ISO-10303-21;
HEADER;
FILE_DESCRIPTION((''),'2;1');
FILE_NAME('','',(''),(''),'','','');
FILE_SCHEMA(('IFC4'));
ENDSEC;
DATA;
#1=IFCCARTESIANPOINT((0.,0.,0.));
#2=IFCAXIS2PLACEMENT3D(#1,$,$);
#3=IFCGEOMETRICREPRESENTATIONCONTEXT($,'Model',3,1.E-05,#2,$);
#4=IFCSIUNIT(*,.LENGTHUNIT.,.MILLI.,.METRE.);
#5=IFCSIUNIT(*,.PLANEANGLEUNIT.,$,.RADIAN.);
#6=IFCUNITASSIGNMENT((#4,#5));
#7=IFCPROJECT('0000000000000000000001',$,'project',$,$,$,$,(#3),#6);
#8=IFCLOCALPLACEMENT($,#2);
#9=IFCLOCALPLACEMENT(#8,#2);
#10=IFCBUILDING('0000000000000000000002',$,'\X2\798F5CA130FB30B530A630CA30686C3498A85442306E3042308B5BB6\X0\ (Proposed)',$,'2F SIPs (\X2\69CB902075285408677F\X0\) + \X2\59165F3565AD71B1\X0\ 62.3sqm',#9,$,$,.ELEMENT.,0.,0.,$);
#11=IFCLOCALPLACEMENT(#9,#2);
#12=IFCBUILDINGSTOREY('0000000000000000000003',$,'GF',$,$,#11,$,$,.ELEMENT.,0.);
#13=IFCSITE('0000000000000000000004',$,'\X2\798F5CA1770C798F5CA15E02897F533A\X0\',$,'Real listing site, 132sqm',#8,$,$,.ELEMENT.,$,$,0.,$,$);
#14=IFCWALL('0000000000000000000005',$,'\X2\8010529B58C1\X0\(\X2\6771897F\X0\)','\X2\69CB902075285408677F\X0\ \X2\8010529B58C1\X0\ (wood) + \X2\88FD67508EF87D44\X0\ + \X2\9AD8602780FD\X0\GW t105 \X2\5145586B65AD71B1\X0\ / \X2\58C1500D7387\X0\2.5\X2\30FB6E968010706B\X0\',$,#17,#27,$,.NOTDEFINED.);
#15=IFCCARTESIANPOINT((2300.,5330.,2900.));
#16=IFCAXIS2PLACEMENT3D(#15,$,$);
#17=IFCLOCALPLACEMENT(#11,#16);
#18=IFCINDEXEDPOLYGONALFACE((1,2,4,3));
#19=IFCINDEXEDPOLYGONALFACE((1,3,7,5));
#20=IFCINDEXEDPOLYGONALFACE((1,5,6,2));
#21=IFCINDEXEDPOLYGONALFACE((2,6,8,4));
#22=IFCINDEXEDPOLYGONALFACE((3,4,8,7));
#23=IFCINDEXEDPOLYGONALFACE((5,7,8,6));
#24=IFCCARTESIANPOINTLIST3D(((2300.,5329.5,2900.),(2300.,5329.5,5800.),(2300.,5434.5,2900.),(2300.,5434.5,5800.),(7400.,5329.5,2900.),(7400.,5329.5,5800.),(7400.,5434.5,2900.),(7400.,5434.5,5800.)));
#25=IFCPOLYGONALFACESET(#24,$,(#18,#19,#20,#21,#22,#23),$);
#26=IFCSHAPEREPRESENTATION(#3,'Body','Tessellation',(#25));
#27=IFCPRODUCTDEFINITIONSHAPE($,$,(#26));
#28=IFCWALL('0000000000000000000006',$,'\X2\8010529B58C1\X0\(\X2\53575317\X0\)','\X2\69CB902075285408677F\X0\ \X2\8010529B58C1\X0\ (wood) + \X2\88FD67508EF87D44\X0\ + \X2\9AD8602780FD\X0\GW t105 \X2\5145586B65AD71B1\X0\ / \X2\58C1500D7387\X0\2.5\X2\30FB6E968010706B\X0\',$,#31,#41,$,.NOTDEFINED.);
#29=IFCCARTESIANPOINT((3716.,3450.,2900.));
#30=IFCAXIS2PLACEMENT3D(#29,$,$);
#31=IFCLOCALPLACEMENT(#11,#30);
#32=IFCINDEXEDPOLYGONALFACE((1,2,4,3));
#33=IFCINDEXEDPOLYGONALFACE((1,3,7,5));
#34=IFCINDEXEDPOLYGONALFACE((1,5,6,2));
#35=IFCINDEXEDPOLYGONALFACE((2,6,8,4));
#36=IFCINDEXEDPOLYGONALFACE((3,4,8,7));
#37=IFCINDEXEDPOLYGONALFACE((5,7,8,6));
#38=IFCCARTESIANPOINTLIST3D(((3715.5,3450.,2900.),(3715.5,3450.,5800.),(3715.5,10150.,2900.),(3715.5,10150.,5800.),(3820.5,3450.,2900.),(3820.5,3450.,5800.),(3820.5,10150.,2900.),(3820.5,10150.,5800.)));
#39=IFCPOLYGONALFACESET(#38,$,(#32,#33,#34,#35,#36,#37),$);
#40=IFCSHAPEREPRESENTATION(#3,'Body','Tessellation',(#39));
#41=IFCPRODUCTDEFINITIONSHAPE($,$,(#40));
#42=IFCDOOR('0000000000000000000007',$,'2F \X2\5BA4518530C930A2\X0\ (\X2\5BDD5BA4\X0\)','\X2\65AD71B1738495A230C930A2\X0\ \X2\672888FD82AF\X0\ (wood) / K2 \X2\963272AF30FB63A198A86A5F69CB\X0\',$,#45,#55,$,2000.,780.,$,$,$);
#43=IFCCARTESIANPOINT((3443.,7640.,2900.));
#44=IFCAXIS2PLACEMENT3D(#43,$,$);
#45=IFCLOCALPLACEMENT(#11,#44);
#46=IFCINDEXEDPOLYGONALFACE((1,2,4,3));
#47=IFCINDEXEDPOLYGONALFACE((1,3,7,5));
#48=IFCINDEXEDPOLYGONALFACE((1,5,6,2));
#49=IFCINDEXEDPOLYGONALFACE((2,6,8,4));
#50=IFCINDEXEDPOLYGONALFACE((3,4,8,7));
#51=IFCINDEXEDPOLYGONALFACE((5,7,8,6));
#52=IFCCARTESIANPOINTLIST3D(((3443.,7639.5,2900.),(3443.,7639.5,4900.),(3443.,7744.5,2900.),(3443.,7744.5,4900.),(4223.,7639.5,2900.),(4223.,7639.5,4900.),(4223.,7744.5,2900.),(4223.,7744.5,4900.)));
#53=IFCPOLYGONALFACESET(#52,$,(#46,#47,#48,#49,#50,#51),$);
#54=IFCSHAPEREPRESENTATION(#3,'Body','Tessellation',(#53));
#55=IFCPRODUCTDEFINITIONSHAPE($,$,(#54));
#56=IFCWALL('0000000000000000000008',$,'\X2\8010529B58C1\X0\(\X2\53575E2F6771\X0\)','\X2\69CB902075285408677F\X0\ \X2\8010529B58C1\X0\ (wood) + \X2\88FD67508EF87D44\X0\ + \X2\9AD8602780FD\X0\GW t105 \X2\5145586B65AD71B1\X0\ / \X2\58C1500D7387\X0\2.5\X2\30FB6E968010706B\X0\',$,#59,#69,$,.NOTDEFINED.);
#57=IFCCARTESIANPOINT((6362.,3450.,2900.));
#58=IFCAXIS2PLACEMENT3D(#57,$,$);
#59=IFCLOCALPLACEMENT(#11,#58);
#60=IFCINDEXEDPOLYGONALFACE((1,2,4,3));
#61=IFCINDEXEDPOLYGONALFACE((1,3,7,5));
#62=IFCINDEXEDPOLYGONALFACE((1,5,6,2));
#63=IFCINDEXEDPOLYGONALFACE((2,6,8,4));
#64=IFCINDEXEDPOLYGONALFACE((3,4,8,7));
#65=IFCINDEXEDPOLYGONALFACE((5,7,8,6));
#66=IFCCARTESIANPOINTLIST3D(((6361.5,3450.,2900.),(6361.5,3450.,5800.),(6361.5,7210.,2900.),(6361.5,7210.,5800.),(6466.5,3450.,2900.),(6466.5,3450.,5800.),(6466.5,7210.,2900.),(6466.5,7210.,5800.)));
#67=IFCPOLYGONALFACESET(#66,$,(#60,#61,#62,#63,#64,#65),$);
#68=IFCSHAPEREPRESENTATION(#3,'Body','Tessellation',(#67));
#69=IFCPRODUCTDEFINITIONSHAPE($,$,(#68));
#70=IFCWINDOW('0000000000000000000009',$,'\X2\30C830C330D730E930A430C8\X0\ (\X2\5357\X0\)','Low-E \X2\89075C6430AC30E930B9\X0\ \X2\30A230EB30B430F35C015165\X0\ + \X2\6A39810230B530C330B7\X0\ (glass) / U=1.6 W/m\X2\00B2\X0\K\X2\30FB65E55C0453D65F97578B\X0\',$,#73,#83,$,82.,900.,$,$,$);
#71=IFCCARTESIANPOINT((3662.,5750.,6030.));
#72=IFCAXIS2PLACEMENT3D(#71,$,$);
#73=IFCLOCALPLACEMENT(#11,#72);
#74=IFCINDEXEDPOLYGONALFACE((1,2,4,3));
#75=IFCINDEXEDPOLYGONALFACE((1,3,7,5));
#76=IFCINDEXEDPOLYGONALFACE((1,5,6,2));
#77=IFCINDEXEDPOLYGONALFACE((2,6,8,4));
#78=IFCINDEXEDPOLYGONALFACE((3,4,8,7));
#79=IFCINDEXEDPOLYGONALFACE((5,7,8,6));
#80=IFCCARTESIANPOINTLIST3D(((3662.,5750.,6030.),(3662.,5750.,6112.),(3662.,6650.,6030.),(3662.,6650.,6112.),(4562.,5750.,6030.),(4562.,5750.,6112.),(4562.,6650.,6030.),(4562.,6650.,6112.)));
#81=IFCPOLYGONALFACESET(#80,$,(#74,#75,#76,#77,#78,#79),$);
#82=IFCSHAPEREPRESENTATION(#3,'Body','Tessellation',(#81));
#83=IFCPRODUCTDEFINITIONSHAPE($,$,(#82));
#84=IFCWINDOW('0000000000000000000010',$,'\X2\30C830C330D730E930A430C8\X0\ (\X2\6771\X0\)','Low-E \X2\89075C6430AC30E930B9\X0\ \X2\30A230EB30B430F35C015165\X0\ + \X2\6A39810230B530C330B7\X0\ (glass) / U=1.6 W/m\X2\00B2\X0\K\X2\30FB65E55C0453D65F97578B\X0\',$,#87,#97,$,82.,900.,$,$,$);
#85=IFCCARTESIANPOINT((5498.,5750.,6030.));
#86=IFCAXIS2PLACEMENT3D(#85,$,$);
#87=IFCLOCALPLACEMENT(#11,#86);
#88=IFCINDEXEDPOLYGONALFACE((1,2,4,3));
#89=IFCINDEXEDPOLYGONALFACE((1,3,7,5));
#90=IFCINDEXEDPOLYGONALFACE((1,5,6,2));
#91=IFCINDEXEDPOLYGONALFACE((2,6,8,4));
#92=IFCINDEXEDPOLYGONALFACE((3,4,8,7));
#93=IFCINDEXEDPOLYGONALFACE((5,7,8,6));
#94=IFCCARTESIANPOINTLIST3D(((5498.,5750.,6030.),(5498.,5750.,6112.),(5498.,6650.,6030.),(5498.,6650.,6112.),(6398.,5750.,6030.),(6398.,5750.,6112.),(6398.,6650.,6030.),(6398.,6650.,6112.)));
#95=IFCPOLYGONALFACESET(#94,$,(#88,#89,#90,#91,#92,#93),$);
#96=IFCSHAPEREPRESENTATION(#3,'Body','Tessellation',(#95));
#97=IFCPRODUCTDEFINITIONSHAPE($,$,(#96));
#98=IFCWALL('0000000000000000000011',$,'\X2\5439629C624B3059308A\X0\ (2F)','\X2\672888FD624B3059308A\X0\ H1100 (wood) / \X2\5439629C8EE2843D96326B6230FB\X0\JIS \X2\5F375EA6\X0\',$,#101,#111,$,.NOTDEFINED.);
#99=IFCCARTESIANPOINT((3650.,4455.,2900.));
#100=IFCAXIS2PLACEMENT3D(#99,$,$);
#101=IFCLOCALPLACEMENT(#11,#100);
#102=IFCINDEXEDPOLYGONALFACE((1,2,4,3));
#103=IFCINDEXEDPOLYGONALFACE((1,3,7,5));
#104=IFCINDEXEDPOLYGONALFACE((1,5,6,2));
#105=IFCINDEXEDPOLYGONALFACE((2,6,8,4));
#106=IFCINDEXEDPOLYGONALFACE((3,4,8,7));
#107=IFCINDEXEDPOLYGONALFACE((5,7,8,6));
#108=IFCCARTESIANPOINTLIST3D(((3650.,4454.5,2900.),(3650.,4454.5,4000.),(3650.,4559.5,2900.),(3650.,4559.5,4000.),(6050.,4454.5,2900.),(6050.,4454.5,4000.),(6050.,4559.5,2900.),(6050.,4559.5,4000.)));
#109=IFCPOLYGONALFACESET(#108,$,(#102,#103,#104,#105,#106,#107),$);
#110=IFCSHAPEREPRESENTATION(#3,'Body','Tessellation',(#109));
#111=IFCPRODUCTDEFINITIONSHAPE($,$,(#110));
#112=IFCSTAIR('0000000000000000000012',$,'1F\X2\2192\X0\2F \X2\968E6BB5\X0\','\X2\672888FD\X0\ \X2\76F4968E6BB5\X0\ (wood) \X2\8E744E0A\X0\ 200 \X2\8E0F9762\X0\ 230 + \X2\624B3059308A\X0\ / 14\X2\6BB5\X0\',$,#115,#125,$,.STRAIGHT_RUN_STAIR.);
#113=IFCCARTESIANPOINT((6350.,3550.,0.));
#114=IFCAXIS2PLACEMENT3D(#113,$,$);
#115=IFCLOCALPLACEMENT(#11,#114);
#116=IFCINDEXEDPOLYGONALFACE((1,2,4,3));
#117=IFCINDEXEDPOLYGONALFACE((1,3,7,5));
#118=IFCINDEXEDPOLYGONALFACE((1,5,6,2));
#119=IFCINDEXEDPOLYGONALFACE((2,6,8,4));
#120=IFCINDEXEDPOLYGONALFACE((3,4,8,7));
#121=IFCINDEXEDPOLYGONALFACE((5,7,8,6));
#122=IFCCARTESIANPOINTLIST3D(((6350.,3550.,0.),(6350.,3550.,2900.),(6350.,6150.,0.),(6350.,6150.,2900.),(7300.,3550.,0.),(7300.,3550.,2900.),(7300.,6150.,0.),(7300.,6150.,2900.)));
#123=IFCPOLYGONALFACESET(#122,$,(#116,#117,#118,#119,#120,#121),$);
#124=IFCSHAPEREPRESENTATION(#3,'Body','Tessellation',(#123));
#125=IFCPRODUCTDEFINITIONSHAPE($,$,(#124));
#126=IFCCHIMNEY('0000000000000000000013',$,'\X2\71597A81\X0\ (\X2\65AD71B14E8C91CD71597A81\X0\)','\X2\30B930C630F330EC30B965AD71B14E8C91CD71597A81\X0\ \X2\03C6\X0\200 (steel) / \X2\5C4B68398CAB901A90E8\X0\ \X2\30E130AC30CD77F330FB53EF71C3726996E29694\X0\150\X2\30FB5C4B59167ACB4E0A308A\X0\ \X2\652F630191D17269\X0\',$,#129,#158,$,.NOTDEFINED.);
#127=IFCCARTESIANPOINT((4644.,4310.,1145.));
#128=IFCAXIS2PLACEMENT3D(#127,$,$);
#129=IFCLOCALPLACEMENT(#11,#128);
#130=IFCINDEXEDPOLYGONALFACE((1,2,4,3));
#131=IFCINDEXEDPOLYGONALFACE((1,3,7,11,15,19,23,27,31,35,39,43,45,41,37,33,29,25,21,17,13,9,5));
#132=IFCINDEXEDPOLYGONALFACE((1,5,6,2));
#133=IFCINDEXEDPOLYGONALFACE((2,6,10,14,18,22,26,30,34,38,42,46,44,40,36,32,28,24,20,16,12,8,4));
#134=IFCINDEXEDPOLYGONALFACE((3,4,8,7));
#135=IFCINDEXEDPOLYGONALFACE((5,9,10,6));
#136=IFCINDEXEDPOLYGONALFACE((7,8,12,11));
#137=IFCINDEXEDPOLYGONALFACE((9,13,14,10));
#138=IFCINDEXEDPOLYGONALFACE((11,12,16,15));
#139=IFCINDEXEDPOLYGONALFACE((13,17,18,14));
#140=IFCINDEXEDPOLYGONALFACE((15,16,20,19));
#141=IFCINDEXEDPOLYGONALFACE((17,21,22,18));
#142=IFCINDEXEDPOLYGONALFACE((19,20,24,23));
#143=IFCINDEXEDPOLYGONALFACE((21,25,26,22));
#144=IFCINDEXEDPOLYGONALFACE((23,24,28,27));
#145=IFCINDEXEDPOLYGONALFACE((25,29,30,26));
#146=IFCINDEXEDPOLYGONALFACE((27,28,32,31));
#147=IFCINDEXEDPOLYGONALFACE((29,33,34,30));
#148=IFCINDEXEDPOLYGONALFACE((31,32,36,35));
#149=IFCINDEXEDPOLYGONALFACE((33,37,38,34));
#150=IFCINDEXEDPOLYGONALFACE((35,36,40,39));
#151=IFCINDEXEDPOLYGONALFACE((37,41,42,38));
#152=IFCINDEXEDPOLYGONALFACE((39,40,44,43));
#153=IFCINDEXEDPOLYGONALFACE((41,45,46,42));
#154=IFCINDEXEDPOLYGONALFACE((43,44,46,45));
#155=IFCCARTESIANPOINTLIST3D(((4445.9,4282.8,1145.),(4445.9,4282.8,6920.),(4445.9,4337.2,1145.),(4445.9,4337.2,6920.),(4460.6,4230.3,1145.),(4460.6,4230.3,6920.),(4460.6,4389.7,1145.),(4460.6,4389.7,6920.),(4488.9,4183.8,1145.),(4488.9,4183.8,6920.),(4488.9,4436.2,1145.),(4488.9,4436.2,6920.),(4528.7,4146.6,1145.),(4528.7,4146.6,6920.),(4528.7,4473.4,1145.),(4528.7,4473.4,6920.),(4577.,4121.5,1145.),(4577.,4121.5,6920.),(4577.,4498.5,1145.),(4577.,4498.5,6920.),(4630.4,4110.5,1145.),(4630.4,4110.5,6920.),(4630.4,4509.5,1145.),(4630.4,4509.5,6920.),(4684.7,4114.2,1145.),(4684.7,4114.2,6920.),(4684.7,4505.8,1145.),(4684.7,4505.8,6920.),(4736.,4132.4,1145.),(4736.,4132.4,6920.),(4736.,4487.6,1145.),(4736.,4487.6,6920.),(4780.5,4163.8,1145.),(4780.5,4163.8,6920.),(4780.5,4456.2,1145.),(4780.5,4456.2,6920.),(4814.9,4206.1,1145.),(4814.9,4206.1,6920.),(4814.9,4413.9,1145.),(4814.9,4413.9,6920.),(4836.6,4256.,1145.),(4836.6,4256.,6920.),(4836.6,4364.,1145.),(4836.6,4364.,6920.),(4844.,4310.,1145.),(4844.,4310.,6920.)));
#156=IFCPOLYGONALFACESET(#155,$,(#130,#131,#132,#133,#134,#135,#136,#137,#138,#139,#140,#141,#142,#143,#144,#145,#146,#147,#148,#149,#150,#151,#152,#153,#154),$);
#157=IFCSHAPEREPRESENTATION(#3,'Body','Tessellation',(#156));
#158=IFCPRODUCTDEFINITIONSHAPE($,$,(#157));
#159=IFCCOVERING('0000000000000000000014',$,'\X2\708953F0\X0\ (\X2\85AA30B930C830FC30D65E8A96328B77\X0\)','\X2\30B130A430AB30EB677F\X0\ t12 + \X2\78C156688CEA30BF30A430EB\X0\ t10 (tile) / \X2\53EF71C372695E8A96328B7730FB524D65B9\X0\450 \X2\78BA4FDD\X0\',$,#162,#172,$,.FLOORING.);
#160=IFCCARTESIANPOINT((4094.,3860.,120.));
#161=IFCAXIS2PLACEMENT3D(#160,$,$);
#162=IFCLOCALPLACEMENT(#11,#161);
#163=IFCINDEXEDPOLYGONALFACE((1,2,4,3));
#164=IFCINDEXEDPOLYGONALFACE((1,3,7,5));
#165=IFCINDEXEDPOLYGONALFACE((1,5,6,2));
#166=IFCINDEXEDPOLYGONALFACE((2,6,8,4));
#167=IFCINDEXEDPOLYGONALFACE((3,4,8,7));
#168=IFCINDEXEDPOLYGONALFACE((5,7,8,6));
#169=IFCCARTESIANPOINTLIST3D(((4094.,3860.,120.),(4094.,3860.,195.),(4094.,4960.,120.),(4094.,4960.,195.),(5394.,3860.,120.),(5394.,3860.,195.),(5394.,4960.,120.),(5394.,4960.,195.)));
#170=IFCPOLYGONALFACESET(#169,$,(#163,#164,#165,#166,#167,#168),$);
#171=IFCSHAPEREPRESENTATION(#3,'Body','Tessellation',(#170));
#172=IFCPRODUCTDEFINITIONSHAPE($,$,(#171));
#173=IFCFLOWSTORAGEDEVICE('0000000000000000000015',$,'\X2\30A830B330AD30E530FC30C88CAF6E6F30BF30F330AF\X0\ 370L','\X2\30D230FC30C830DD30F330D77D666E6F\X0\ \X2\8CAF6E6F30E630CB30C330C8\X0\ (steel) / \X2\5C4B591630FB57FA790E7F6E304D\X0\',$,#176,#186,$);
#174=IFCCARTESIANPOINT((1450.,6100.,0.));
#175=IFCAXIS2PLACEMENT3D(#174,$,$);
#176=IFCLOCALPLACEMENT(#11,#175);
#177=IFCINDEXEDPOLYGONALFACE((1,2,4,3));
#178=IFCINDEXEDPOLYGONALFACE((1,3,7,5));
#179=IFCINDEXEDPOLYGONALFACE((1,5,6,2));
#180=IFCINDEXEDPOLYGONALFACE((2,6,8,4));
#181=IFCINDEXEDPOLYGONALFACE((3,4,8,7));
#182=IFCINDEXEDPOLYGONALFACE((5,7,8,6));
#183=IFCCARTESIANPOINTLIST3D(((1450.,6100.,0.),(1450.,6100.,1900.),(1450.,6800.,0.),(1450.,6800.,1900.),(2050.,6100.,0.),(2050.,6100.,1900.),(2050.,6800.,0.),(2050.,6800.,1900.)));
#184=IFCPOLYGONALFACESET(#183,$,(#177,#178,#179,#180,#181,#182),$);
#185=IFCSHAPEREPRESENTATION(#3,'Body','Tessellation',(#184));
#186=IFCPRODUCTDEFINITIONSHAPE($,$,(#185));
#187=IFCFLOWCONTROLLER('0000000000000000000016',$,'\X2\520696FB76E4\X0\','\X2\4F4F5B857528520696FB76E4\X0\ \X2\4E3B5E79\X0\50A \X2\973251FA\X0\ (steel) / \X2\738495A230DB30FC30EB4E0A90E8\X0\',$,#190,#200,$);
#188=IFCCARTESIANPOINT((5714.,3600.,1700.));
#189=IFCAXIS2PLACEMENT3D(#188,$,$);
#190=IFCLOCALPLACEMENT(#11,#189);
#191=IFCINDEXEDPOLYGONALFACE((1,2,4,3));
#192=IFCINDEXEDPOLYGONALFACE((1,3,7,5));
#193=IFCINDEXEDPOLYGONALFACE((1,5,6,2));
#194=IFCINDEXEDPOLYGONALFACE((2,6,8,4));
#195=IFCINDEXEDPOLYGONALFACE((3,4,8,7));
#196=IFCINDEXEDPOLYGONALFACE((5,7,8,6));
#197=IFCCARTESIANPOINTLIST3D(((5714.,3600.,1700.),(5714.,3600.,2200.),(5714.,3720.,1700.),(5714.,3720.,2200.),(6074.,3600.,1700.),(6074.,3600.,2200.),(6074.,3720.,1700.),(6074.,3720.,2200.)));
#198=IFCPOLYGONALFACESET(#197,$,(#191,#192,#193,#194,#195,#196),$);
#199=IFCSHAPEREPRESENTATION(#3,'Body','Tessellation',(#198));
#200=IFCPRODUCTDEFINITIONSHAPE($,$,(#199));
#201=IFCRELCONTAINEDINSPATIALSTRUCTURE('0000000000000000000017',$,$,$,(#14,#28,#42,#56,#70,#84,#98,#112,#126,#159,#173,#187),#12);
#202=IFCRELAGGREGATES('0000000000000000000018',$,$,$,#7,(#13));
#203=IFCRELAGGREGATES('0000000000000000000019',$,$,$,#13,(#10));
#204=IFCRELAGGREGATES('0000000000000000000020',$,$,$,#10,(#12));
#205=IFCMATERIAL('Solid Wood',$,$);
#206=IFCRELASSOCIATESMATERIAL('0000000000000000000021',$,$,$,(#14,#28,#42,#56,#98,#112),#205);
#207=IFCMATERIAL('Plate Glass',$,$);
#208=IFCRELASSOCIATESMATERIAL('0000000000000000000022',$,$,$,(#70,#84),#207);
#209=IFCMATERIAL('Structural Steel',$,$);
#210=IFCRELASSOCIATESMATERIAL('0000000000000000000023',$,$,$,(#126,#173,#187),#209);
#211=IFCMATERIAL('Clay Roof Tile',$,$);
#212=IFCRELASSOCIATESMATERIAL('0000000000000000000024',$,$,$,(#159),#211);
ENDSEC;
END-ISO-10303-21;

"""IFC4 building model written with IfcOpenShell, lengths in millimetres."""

from ifc_helpers import new_model, si_unit, frame, frame_2d, origin, origin_2d, place, context, project, spatial, rectangle, circle, extrude, material, element, fill, save


model = new_model("IFC4")

# Units and contexts
model_context = context("Model", 3, precision=1e-05, world=origin())
ifc_project = project(units=[si_unit("LENGTHUNIT", "METRE", prefix="MILLI"), si_unit("PLANEANGLEUNIT", "RADIAN")], contexts=[model_context])

# Site, building, storey
site_placement = place(None, origin())
site = spatial("IfcSite", under=ifc_project, at=site_placement, Name="福岡県福岡市西区", ObjectType="Real listing site, 132sqm", CompositionType="ELEMENT", RefElevation=0.0)
building_placement = place(site_placement, origin())
building = spatial("IfcBuilding", under=site, at=building_placement, Name="福岡・サウナと水風呂のある家 (Proposed)", ObjectType="2F SIPs (構造用合板) + 外張断熱 62.3sqm", CompositionType="ELEMENT", ElevationOfRefHeight=0.0, ElevationOfTerrain=0.0)
storey_placement = place(building_placement, origin())
storey = spatial("IfcBuildingStorey", under=building, at=storey_placement, Name="GF", CompositionType="ELEMENT", Elevation=0.0)

# Shared definitions
ifc_material_1 = material(Name="Solid Wood")

# Wall
wall_1_placement = place(storey_placement, frame((2300.0, 5330.0, 2900.0)))
element("IfcWall", 1, at=wall_1_placement, inside=storey, material=ifc_material_1, Name="耐力壁(東西)", Description="構造用合板 耐力壁 (wood) + 製材軸組 + 高性能GW t105 充填断熱 / 壁倍率2.5・準耐火", PredefinedType="NOTDEFINED", context=model_context, shape_type="SweptSolid", body=[
    extrude(rectangle(XDim=5100.0, YDim=105.0, at=frame_2d((2550.0, 52.0))), frame((2300.0, 5330.0, 2900.0)), (0.0, 0.0, 1.0), 2900.0),
])

# Wall, opening, door
wall_2_placement = place(storey_placement, frame((3716.0, 3450.0, 2900.0)))
wall_2 = element("IfcWall", 2, at=wall_2_placement, inside=storey, material=ifc_material_1, Name="耐力壁(南北)", Description="構造用合板 耐力壁 (wood) + 製材軸組 + 高性能GW t105 充填断熱 / 壁倍率2.5・準耐火", PredefinedType="NOTDEFINED", context=model_context, shape_type="SweptSolid", body=[
    extrude(rectangle(XDim=105.0, YDim=6700.0, at=frame_2d((52.0, 3350.0))), frame((3716.0, 3450.0, 2900.0)), (0.0, 0.0, 1.0), 2900.0),
])
opening_placement = place(storey_placement, frame((3443.0, 7640.0, 2900.0)))
opening = element("IfcOpeningElement", 3, at=opening_placement, cuts=wall_2, PredefinedType="NOTDEFINED", context=model_context, shape_type="SweptSolid", body=[
    extrude(rectangle(XDim=780.0, YDim=105.0, at=frame_2d((390.0, 52.0))), frame((3443.0, 7640.0, 2900.0)), (0.0, 0.0, 1.0), 2000.0),
])
door_placement = place(storey_placement, frame((3443.0, 7640.0, 2900.0)))
door = element("IfcDoor", 4, at=door_placement, inside=storey, material=ifc_material_1, Name="2F 室内ドア (寝室)", Description="断熱玄関ドア 木製芯 (wood) / K2 防犯・採風機構", OverallHeight=2000.0, OverallWidth=780.0, context=model_context, shape_type="SweptSolid", body=[
    extrude(rectangle(XDim=780.0, YDim=105.0, at=frame_2d((390.0, 52.0))), frame((3443.0, 7640.0, 2900.0)), (0.0, 0.0, 1.0), 2000.0),
])
fill(opening, door)

# Wall
wall_3_placement = place(storey_placement, frame((6362.0, 3450.0, 2900.0)))
element("IfcWall", 5, at=wall_3_placement, inside=storey, material=ifc_material_1, Name="耐力壁(南帯東)", Description="構造用合板 耐力壁 (wood) + 製材軸組 + 高性能GW t105 充填断熱 / 壁倍率2.5・準耐火", PredefinedType="NOTDEFINED", context=model_context, shape_type="SweptSolid", body=[
    extrude(rectangle(XDim=105.0, YDim=3760.0, at=frame_2d((52.0, 1880.0))), frame((6362.0, 3450.0, 2900.0)), (0.0, 0.0, 1.0), 2900.0),
])

# Windows
ifc_material_2 = material(Name="Plate Glass")
window_1_placement = place(storey_placement, frame((3662.0, 5750.0, 6030.0)))
element("IfcWindow", 6, at=window_1_placement, inside=storey, material=ifc_material_2, Name="トップライト (南)", Description="Low-E 複層ガラス アルゴン封入 + 樹脂サッシ (glass) / U=1.6 W/m²K・日射取得型", OverallHeight=82.0, OverallWidth=900.0, context=model_context, shape_type="SweptSolid", body=[
    extrude(rectangle(XDim=900.0, YDim=900.0, at=frame_2d((450.0, 450.0))), frame((3662.0, 5750.0, 6030.0)), (0.0, 0.0, 1.0), 82.0),
])
window_2_placement = place(storey_placement, frame((5498.0, 5750.0, 6030.0)))
element("IfcWindow", 7, at=window_2_placement, inside=storey, material=ifc_material_2, Name="トップライト (東)", Description="Low-E 複層ガラス アルゴン封入 + 樹脂サッシ (glass) / U=1.6 W/m²K・日射取得型", OverallHeight=82.0, OverallWidth=900.0, context=model_context, shape_type="SweptSolid", body=[
    extrude(rectangle(XDim=900.0, YDim=900.0, at=frame_2d((450.0, 450.0))), frame((5498.0, 5750.0, 6030.0)), (0.0, 0.0, 1.0), 82.0),
])

# Wall
wall_4_placement = place(storey_placement, frame((3650.0, 4455.0, 2900.0)))
element("IfcWall", 8, at=wall_4_placement, inside=storey, material=ifc_material_1, Name="吹抜手すり (2F)", Description="木製手すり H1100 (wood) / 吹抜転落防止・JIS 強度", PredefinedType="NOTDEFINED", context=model_context, shape_type="SweptSolid", body=[
    extrude(rectangle(XDim=2400.0, YDim=105.0, at=frame_2d((1200.0, 52.0))), frame((3650.0, 4455.0, 2900.0)), (0.0, 0.0, 1.0), 1100.0),
])

# Stair
stair_placement = place(storey_placement, frame((6350.0, 3550.0, 0.0)))
element("IfcStair", 9, at=stair_placement, inside=storey, material=ifc_material_1, Name="1F→2F 階段", Description="木製 直階段 (wood) 蹴上 200 踏面 230 + 手すり / 14段", PredefinedType="STRAIGHT_RUN_STAIR", context=model_context, shape_type="SweptSolid", body=[
    extrude(rectangle(XDim=950.0, YDim=2600.0, at=frame_2d((475.0, 1300.0))), frame((6350.0, 3550.0, 0.0)), (0.0, 0.0, 1.0), 2900.0),
])

# Chimney
ifc_material_3 = material(Name="Structural Steel")
chimney_placement = place(storey_placement, frame((4644.0, 4310.0, 1145.0)))
element("IfcChimney", 10, at=chimney_placement, inside=storey, material=ifc_material_3, Name="煙突 (断熱二重煙突)", Description="ステンレス断熱二重煙突 φ200 (steel) / 屋根貫通部 メガネ石・可燃物離隔150・屋外立上り 支持金物", PredefinedType="NOTDEFINED", context=model_context, shape_type="SweptSolid", body=[
    extrude(circle(Radius=200.0, at=origin_2d()), frame((4644.0, 4310.0, 1145.0)), (0.0, 0.0, 1.0), 5775.0),
])

# Covering
ifc_material_4 = material(Name="Clay Roof Tile")
covering_placement = place(storey_placement, frame((4094.0, 3860.0, 120.0)))
element("IfcCovering", 11, at=covering_placement, inside=storey, material=ifc_material_4, Name="炉台 (薪ストーブ床防護)", Description="ケイカル板 t12 + 磁器質タイル t10 (tile) / 可燃物床防護・前方450 確保", PredefinedType="FLOORING", context=model_context, shape_type="SweptSolid", body=[
    extrude(rectangle(XDim=1300.0, YDim=1100.0, at=frame_2d((650.0, 550.0))), frame((4094.0, 3860.0, 120.0)), (0.0, 0.0, 1.0), 75.0),
])

# Flow storage device
flow_storage_device_placement = place(storey_placement, frame((1450.0, 6100.0, 0.0)))
element("IfcFlowStorageDevice", 12, at=flow_storage_device_placement, inside=storey, material=ifc_material_3, Name="エコキュート貯湯タンク 370L", Description="ヒートポンプ給湯 貯湯ユニット (steel) / 屋外・基礎置き", context=model_context, shape_type="SweptSolid", body=[
    extrude(rectangle(XDim=600.0, YDim=700.0, at=frame_2d((300.0, 350.0))), frame((1450.0, 6100.0, 0.0)), (0.0, 0.0, 1.0), 1900.0),
])

# Flow controller
flow_controller_placement = place(storey_placement, frame((5714.0, 3600.0, 1700.0)))
element("IfcFlowController", 13, at=flow_controller_placement, inside=storey, material=ifc_material_3, Name="分電盤", Description="住宅用分電盤 主幹50A 露出 (steel) / 玄関ホール上部", context=model_context, shape_type="SweptSolid", body=[
    extrude(rectangle(XDim=360.0, YDim=120.0, at=frame_2d((180.0, 60.0))), frame((5714.0, 3600.0, 1700.0)), (0.0, 0.0, 1.0), 500.0),
])

save(model, "model.ifc")
